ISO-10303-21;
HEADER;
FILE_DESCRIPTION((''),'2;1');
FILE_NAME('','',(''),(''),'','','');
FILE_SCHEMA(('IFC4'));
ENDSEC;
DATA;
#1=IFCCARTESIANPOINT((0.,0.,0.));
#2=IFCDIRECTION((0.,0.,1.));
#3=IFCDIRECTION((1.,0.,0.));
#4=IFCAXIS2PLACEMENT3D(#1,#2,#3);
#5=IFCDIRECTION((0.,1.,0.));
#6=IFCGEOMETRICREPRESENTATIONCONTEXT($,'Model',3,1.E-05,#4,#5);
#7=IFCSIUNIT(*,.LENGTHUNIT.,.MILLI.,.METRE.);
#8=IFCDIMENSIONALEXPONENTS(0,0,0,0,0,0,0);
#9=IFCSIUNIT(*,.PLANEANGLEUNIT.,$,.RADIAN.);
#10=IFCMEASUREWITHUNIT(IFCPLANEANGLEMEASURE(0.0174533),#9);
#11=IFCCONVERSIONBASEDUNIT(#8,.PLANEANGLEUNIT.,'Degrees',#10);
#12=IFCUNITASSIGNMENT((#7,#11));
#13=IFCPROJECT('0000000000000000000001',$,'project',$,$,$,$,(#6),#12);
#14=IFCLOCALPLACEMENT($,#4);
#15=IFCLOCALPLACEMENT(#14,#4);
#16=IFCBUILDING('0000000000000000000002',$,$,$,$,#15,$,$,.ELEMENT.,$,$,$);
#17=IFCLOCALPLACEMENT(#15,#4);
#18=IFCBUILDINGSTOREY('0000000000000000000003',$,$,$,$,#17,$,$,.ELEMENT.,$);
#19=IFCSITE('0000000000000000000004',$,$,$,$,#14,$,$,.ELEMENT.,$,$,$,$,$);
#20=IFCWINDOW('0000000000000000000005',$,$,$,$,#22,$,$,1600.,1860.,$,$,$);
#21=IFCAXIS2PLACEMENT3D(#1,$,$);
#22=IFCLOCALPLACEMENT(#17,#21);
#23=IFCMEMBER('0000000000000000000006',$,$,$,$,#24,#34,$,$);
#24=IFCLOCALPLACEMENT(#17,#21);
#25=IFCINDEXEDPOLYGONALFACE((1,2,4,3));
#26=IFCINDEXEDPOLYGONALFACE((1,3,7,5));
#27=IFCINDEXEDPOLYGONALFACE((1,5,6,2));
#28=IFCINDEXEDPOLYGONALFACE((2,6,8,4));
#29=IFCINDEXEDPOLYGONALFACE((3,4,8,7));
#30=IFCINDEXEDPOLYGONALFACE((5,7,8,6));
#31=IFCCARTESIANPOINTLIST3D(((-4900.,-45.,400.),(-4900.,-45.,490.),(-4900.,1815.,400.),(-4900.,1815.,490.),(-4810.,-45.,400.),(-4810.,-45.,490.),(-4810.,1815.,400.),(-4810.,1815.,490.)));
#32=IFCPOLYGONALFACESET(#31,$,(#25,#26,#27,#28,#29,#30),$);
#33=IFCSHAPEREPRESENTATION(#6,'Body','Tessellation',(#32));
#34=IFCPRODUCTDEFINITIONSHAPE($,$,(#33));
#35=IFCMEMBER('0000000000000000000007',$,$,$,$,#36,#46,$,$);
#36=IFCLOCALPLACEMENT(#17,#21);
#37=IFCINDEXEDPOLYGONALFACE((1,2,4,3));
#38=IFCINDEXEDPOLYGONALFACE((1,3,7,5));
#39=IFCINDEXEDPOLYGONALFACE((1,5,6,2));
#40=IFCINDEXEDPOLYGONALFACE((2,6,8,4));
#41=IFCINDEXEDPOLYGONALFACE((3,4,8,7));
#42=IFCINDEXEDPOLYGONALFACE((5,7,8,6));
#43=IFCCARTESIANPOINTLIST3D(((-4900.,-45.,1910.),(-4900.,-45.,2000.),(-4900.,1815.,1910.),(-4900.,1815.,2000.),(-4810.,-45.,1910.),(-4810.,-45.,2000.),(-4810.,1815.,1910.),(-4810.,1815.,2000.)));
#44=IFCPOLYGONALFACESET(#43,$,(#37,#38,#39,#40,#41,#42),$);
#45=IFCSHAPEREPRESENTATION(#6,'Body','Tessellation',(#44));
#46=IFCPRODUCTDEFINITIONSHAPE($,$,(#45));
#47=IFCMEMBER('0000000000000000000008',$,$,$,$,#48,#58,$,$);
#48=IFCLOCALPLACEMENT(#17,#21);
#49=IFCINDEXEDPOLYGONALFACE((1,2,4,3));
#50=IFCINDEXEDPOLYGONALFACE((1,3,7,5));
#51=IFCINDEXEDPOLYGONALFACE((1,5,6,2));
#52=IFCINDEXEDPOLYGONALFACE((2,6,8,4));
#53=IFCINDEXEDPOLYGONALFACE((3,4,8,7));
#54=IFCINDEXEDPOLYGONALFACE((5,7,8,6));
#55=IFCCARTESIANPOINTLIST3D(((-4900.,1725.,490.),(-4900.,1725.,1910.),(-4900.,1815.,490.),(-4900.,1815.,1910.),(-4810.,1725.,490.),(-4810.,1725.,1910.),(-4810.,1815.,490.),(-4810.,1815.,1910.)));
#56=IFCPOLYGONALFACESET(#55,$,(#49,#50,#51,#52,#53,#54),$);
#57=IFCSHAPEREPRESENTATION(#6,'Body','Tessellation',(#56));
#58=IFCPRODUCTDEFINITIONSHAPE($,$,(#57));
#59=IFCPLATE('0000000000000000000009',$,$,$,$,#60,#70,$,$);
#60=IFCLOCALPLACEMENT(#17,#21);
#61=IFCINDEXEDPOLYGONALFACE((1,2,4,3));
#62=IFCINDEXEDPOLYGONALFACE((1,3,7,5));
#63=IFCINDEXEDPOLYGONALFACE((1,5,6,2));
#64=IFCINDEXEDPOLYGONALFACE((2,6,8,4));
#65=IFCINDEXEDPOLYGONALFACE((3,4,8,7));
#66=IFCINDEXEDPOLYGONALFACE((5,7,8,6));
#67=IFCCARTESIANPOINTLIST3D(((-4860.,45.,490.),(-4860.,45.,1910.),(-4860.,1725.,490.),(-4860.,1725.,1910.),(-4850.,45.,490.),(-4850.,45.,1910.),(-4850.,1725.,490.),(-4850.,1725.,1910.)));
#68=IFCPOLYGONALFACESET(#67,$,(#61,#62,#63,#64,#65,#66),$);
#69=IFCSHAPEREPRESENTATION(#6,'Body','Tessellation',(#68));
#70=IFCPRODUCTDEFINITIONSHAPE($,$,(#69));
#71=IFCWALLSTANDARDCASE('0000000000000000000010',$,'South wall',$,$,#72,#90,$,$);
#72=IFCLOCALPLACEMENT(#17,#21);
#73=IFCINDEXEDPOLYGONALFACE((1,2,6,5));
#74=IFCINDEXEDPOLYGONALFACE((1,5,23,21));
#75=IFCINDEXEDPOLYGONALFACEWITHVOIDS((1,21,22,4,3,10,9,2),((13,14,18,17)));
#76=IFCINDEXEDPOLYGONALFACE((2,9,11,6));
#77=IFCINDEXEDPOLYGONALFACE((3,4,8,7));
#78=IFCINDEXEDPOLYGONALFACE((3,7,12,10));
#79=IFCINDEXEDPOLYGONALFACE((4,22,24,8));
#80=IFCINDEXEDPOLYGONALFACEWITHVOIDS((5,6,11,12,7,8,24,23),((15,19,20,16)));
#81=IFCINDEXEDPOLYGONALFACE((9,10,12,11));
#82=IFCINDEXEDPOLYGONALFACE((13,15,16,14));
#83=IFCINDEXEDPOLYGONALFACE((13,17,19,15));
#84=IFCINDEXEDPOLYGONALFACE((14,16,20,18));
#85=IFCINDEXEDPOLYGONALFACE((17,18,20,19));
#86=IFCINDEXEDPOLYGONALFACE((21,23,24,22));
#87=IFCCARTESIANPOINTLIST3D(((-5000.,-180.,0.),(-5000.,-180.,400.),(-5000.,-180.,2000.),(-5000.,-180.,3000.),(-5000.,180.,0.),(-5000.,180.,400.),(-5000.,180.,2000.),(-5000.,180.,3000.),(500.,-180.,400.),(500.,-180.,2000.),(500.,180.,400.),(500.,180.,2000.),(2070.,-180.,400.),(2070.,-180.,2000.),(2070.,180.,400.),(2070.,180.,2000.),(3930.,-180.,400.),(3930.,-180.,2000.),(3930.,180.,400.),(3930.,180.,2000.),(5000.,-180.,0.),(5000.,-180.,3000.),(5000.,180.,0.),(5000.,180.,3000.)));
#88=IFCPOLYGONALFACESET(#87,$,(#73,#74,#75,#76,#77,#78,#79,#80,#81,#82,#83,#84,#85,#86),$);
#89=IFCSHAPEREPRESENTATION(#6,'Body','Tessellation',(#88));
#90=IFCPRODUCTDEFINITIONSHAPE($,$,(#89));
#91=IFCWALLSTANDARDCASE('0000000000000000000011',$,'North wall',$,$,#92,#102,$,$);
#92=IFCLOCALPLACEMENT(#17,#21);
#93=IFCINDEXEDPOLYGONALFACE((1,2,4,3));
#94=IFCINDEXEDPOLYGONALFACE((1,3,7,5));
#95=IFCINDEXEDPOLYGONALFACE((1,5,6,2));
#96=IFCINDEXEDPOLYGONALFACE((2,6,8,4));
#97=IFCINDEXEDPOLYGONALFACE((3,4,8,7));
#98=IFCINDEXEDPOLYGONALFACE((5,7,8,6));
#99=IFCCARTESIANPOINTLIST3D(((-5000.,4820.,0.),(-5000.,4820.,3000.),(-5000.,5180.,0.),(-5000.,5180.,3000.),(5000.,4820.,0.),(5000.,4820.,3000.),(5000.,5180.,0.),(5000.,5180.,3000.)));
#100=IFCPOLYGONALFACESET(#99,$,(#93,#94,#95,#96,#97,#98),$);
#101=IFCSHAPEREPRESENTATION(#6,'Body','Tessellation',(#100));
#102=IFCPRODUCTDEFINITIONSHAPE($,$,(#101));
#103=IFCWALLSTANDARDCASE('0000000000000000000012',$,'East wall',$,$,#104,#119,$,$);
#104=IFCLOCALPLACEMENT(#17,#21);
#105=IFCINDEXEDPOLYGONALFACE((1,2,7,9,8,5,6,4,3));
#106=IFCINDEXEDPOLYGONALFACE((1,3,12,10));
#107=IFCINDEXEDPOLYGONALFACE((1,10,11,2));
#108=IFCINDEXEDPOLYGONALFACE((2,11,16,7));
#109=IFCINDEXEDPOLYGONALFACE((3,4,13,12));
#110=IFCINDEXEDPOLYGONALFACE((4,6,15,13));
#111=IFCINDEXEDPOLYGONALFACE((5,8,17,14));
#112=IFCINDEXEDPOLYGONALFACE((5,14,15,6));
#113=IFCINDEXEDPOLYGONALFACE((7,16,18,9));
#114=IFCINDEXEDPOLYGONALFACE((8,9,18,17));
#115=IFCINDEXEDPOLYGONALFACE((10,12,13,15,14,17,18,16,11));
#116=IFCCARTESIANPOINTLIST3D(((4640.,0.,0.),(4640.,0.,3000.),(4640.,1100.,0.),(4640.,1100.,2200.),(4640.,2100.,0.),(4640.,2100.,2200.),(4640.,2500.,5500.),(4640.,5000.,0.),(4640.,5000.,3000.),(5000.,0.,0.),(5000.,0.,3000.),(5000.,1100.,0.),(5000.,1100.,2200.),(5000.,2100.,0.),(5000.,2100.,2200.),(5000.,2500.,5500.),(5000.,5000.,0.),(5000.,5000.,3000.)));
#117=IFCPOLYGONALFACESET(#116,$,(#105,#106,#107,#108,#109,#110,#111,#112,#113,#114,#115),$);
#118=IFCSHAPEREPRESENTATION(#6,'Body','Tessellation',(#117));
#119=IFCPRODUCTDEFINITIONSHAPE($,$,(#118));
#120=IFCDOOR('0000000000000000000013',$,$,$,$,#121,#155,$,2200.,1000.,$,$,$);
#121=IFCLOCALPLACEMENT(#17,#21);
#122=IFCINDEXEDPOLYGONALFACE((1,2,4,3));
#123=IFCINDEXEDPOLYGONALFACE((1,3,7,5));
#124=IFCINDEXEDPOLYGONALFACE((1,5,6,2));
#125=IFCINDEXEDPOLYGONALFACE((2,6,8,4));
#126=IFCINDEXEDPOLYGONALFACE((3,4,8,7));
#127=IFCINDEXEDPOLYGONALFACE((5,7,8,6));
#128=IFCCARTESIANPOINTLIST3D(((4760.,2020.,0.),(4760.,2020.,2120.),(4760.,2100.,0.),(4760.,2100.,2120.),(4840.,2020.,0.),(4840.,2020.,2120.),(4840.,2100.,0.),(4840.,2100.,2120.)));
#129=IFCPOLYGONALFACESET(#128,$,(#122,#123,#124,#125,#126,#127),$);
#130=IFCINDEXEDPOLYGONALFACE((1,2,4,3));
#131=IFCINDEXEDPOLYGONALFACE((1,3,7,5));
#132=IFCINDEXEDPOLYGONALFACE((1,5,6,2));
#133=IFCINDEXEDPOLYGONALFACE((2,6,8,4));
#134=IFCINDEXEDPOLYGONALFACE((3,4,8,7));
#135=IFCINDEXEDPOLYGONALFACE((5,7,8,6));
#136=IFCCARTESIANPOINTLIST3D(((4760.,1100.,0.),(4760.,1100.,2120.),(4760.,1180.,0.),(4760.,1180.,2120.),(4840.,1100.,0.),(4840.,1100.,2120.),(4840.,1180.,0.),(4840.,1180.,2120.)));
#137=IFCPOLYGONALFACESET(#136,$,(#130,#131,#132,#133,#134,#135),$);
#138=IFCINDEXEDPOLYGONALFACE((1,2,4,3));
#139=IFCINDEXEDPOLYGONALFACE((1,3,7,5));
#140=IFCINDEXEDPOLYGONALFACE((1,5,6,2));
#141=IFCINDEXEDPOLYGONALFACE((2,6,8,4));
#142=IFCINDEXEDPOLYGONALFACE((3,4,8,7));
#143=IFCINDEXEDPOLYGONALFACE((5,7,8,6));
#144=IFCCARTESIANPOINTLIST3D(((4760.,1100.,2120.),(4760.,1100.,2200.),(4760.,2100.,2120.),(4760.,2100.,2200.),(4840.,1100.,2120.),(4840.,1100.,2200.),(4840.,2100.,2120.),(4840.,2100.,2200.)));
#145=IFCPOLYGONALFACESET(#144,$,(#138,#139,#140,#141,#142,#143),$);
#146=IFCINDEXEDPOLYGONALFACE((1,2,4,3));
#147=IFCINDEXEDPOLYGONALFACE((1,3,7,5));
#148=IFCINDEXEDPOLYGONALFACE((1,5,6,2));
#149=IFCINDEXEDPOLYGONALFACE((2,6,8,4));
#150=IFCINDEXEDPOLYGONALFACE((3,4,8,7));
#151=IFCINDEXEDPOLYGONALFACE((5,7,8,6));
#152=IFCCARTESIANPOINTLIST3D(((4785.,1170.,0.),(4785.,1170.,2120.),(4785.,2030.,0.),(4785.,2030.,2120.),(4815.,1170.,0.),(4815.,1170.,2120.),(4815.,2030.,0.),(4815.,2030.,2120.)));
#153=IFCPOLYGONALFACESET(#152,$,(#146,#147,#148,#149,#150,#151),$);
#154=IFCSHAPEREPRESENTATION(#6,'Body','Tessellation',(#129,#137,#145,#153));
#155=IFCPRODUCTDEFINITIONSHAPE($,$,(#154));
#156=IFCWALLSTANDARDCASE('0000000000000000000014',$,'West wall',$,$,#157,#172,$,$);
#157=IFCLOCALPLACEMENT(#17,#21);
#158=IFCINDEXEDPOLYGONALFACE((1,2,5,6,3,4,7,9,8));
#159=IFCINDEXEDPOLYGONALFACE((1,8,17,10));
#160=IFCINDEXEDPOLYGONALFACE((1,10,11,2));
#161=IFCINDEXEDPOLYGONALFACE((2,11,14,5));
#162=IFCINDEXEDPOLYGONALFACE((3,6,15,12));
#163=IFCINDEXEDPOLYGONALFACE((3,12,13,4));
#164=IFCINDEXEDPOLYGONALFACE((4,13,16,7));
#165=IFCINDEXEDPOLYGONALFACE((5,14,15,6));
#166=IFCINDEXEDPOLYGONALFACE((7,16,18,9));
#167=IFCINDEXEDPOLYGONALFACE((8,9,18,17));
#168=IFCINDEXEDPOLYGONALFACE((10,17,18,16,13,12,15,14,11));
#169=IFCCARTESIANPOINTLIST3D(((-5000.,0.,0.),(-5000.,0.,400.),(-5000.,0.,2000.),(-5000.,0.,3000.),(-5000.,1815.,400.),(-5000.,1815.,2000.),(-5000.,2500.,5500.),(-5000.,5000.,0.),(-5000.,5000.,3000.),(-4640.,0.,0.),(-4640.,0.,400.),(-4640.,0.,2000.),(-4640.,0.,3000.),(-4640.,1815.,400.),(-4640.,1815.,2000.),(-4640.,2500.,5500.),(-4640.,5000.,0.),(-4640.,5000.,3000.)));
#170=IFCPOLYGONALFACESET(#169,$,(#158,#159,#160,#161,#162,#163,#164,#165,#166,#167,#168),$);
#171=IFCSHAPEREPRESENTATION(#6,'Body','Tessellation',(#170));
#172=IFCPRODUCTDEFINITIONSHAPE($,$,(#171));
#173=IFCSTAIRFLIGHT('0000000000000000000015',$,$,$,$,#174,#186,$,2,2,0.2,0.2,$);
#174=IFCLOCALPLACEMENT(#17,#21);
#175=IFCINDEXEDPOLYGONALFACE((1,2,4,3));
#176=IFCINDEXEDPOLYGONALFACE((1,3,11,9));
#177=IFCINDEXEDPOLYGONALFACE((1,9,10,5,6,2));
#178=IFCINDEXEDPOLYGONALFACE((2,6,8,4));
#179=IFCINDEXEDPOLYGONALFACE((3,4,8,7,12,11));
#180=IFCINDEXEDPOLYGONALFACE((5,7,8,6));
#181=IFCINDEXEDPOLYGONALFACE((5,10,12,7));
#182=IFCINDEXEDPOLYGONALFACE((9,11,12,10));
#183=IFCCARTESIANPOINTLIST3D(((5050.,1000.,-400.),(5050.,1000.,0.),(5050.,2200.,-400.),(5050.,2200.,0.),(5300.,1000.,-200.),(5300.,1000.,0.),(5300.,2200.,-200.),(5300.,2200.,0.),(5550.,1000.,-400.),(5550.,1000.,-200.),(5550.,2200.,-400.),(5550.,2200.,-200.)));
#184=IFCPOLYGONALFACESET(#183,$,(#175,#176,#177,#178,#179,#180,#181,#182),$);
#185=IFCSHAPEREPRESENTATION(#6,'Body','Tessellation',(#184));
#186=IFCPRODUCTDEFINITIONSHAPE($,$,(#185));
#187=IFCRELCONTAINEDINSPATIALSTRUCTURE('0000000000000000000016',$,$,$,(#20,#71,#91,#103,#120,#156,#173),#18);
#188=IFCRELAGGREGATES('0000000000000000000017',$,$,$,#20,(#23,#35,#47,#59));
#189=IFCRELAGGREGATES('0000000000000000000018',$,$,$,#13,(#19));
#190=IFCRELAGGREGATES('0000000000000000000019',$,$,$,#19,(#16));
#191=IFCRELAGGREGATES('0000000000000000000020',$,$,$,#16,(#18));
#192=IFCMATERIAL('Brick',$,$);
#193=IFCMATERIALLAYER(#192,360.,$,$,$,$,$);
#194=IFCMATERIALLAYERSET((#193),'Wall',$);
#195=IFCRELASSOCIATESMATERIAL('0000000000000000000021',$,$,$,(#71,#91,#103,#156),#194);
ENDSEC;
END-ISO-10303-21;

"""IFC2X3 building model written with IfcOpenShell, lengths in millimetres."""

from ifc_helpers import new_model, entity, si_unit, converted_unit, direction, frame, origin_with_axes, place, context, project, spatial, polyline, outline, extrude, clip, halfspace, material, layer, layer_set, layer_usage, element, fill, aggregate, save


model = new_model("IFC2X3")

# Units and contexts
model_context = context("Model", 3, precision=1e-05, world=origin_with_axes(), true_north=direction((0.0, 1.0, 0.0)))
ifc_project = project(units=[si_unit("LENGTHUNIT", "METRE", prefix="MILLI"), converted_unit("PLANEANGLEUNIT", "Degrees", entity("IfcPlaneAngleMeasure", 0.0174533), si_unit("PLANEANGLEUNIT", "RADIAN"), dimensions=[0, 0, 0, 0, 0, 0, 0])], contexts=[model_context])

# Site, building, storey
site_placement = place(None, origin_with_axes())
site = spatial("IfcSite", under=ifc_project, at=site_placement, CompositionType="ELEMENT")
building_placement = place(site_placement, origin_with_axes())
building = spatial("IfcBuilding", under=site, at=building_placement, CompositionType="ELEMENT")
storey_placement = place(building_placement, origin_with_axes())
storey = spatial("IfcBuildingStorey", under=building, at=storey_placement, CompositionType="ELEMENT")

# Window, members
window_1_placement = place(storey_placement, frame((-4810.0, -45.0, 400.0), z_axis=(0.0, 0.0, 1.0), x_axis=(0.0, 1.0, 0.0)))
window_1 = element("IfcWindow", 1, at=window_1_placement, inside=storey, OverallHeight=1600.0, OverallWidth=1860.0)
member_1_placement = place(window_1_placement, frame((930.0, 45.0, 0.0), z_axis=(0.0, 0.0, 1.0), x_axis=(1.0, 0.0, 0.0)))
member_1 = element("IfcMember", 2, at=member_1_placement, context=model_context, shape_type="SweptSolid", body=[
    extrude(outline(polyline([(-930.0, -45.0), (930.0, -45.0), (930.0, 45.0), (-930.0, 45.0), (-930.0, -45.0), (-930.0, -45.0)])), origin_with_axes(), (0.0, 0.0, 1.0), 90.0),
])
member_2_placement = place(window_1_placement, frame((930.0, 45.0, 1510.0), z_axis=(0.0, 0.0, 1.0), x_axis=(1.0, 0.0, 0.0)))
member_2 = element("IfcMember", 3, at=member_2_placement, context=model_context, shape_type="SweptSolid", body=[
    extrude(outline(polyline([(-930.0, -45.0), (930.0, -45.0), (930.0, 45.0), (-930.0, 45.0), (-930.0, -45.0), (-930.0, -45.0)])), origin_with_axes(), (0.0, 0.0, 1.0), 90.0),
])
member_3_placement = place(window_1_placement, frame((1815.0, 45.0, 90.0), z_axis=(0.0, 0.0, 1.0), x_axis=(1.0, 0.0, 0.0)))
member_3 = element("IfcMember", 4, at=member_3_placement, context=model_context, shape_type="SweptSolid", body=[
    extrude(outline(polyline([(-45.0, -45.0), (45.0, -45.0), (45.0, 45.0), (-45.0, 45.0), (-45.0, -45.0), (-45.0, -45.0)])), origin_with_axes(), (0.0, 0.0, 1.0), 1420.0),
])

# Plate
plate_1_placement = place(window_1_placement, frame((930.0, 45.0, 90.0), z_axis=(0.0, 0.0, 1.0), x_axis=(1.0, 0.0, 0.0)))
plate_1 = element("IfcPlate", 5, at=plate_1_placement, context=model_context, shape_type="SweptSolid", body=[
    extrude(outline(polyline([(-840.0, -5.0), (840.0, -5.0), (840.0, 5.0), (-840.0, 5.0), (-840.0, -5.0), (-840.0, -5.0)])), origin_with_axes(), (0.0, 0.0, 1.0), 1420.0),
])
aggregate(window_1, [member_1, member_2, member_3, plate_1])

# Wall, openings
ifc_material = material(Name="Brick")
ifc_layer = layer(ifc_material, 360.0)
ifc_layer_set = layer_set([ifc_layer], Name="Wall")
ifc_layer_usage = layer_usage(ifc_layer_set, "AXIS2", "POSITIVE", -180.0)
wall_1_placement = place(None, origin_with_axes())
wall_1 = element("IfcWallStandardCase", 6, at=wall_1_placement, inside=storey, material=ifc_layer_usage, Name="South wall", context=model_context, shape_type="SweptSolid", body=[
    extrude(outline(polyline([(-5000.0, -180.0), (5000.0, -180.0), (5000.0, 180.0), (-5000.0, 180.0), (-5000.0, -180.0), (-5000.0, -180.0)])), origin_with_axes(), (0.0, 0.0, 1.0), 3000.0),
])
placement = place(None, frame((-2500.0, 0.0, 400.0), z_axis=(0.0, 0.0, 1.0), x_axis=(1.0, 0.0, 0.0)))
element("IfcOpeningElement", 7, at=placement, cuts=wall_1, context=model_context, shape_type="SweptSolid", body=[
    extrude(outline(polyline([(-3000.0, -1815.0), (3000.0, -1815.0), (3000.0, 1815.0), (-3000.0, 1815.0), (-3000.0, -1815.0), (-3000.0, -1815.0)])), origin_with_axes(), (0.0, 0.0, 1.0), 1600.0),
])
opening_1_placement = place(None, frame((3000.0, 0.0, 400.0), z_axis=(0.0, 0.0, 1.0), x_axis=(1.0, 0.0, 0.0)))
element("IfcOpeningElement", 8, at=opening_1_placement, cuts=wall_1, context=model_context, shape_type="SweptSolid", body=[
    extrude(outline(polyline([(-930.0, -1500.0), (930.0, -1500.0), (930.0, 1500.0), (-930.0, 1500.0), (-930.0, -1500.0), (-930.0, -1500.0)])), origin_with_axes(), (0.0, 0.0, 1.0), 1600.0),
])

# Wall
wall_2_placement = place(storey_placement, frame((0.0, 5000.0, 0.0), z_axis=(0.0, 0.0, 1.0), x_axis=(1.0, 0.0, 0.0)))
element("IfcWallStandardCase", 9, at=wall_2_placement, inside=storey, material=ifc_layer_usage, Name="North wall", context=model_context, shape_type="SweptSolid", body=[
    extrude(outline(polyline([(-5000.0, -180.0), (5000.0, -180.0), (5000.0, 180.0), (-5000.0, 180.0), (-5000.0, -180.0), (-5000.0, -180.0)])), origin_with_axes(), (0.0, 0.0, 1.0), 3000.0),
])

# Wall, opening, door
wall_3_placement = place(storey_placement, frame((4820.0, 2500.0, 0.0), z_axis=(0.0, 0.0, 1.0), x_axis=(0.0, 1.0, 0.0)))
wall_3 = element("IfcWallStandardCase", 10, at=wall_3_placement, inside=storey, material=ifc_layer_usage, Name="East wall", context=model_context, shape_type="Clipping", body=[
    clip(clip(extrude(outline(polyline([(-2500.0, -180.0), (2500.0, -180.0), (2500.0, 180.0), (-2500.0, 180.0), (-2500.0, -180.0), (-2500.0, -180.0)])), origin_with_axes(), (0.0, 0.0, 1.0), 6000.0), halfspace(frame((-2500.0, 0.0, 3000.0), z_axis=(-1.0, 0.0, 1.0), x_axis=(1.0, 0.0, 0.0)), False)), halfspace(frame((2500.0, 0.0, 3000.0), z_axis=(1.0, 0.0, 1.0), x_axis=(1.0, 0.0, 0.0)), False)),
])
opening_2_placement = place(None, frame((4820.0, 1600.0, 0.0), z_axis=(0.0, 0.0, 1.0), x_axis=(1.0, 0.0, 0.0)))
opening_2 = element("IfcOpeningElement", 11, at=opening_2_placement, cuts=wall_3, context=model_context, shape_type="SweptSolid", body=[
    extrude(outline(polyline([(-500.0, -500.0), (500.0, -500.0), (500.0, 500.0), (-500.0, 500.0), (-500.0, -500.0), (-500.0, -500.0)])), origin_with_axes(), (0.0, 0.0, 1.0), 2200.0),
])
door_placement = place(storey_placement, frame((4800.0, 1600.0, 0.0), z_axis=(0.0, 0.0, 1.0), x_axis=(0.0, 1.0, 0.0)))
door = element("IfcDoor", 12, at=door_placement, inside=storey, OverallHeight=2200.0, OverallWidth=1000.0, context=model_context, shape_type="SweptSolid", body=[
    extrude(outline(polyline([(-40.0, -40.0), (40.0, -40.0), (40.0, 40.0), (-40.0, 40.0), (-40.0, -40.0), (-40.0, -40.0)])), frame((460.0, 0.0, 0.0), z_axis=(0.0, 0.0, 1.0), x_axis=(1.0, 0.0, 0.0)), (0.0, 0.0, 1.0), 2120.0),
    extrude(outline(polyline([(-40.0, -40.0), (40.0, -40.0), (40.0, 40.0), (-40.0, 40.0), (-40.0, -40.0), (-40.0, -40.0)])), frame((-460.0, 0.0, 0.0), z_axis=(0.0, 0.0, 1.0), x_axis=(1.0, 0.0, 0.0)), (0.0, 0.0, 1.0), 2120.0),
    extrude(outline(polyline([(-500.0, -40.0), (500.0, -40.0), (500.0, 40.0), (-500.0, 40.0), (-500.0, -40.0), (-500.0, -40.0)])), frame((0.0, 0.0, 2120.0), z_axis=(0.0, 0.0, 1.0), x_axis=(1.0, 0.0, 0.0)), (0.0, 0.0, 1.0), 80.0),
    extrude(outline(polyline([(-430.0, -15.0), (430.0, -15.0), (430.0, 15.0), (-430.0, 15.0), (-430.0, -15.0), (-430.0, -15.0)])), origin_with_axes(), (0.0, 0.0, 1.0), 2120.0),
])
fill(opening_2, door)

# Wall, opening
wall_4_placement = place(storey_placement, frame((-4820.0, 2500.0, 0.0), z_axis=(0.0, 0.0, 1.0), x_axis=(0.0, -1.0, 0.0)))
wall_4 = element("IfcWallStandardCase", 13, at=wall_4_placement, inside=storey, material=ifc_layer_usage, Name="West wall", context=model_context, shape_type="Clipping", body=[
    clip(clip(extrude(outline(polyline([(-2500.0, -180.0), (2500.0, -180.0), (2500.0, 180.0), (-2500.0, 180.0), (-2500.0, -180.0), (-2500.0, -180.0)])), origin_with_axes(), (0.0, 0.0, 1.0), 6000.0), halfspace(frame((-2500.0, 0.0, 3000.0), z_axis=(-1.0, 0.0, 1.0), x_axis=(1.0, 0.0, 0.0)), False)), halfspace(frame((2500.0, 0.0, 3000.0), z_axis=(1.0, 0.0, 1.0), x_axis=(1.0, 0.0, 0.0)), False)),
])
element("IfcOpeningElement", 14, at=placement, cuts=wall_4, context=model_context, shape_type="SweptSolid", body=[
    extrude(outline(polyline([(-3000.0, -1815.0), (3000.0, -1815.0), (3000.0, 1815.0), (-3000.0, 1815.0), (-3000.0, -1815.0), (-3000.0, -1815.0)])), origin_with_axes(), (0.0, 0.0, 1.0), 1600.0),
])

# Stair flight
stair_flight_placement = place(storey_placement, frame((5050.0, 1000.0, 0.0), z_axis=(0.0, 1.0, 0.0), x_axis=(1.0, 0.0, 0.0)))
element("IfcStairFlight", 15, at=stair_flight_placement, inside=storey, NumberOfRiser=2, NumberOfTreads=2, RiserHeight=0.2, TreadLength=0.2, context=model_context, shape_type="SweptSolid", body=[
    extrude(outline(polyline([(0.0, 0.0), (250.0, 0.0), (250.0, 200.0), (500.0, 200.0), (500.0, 400.0), (0.0, 400.0), (0.0, 0.0)])), origin_with_axes(), (0.0, 0.0, 1.0), 1200.0),
])

save(model, "model.ifc")
